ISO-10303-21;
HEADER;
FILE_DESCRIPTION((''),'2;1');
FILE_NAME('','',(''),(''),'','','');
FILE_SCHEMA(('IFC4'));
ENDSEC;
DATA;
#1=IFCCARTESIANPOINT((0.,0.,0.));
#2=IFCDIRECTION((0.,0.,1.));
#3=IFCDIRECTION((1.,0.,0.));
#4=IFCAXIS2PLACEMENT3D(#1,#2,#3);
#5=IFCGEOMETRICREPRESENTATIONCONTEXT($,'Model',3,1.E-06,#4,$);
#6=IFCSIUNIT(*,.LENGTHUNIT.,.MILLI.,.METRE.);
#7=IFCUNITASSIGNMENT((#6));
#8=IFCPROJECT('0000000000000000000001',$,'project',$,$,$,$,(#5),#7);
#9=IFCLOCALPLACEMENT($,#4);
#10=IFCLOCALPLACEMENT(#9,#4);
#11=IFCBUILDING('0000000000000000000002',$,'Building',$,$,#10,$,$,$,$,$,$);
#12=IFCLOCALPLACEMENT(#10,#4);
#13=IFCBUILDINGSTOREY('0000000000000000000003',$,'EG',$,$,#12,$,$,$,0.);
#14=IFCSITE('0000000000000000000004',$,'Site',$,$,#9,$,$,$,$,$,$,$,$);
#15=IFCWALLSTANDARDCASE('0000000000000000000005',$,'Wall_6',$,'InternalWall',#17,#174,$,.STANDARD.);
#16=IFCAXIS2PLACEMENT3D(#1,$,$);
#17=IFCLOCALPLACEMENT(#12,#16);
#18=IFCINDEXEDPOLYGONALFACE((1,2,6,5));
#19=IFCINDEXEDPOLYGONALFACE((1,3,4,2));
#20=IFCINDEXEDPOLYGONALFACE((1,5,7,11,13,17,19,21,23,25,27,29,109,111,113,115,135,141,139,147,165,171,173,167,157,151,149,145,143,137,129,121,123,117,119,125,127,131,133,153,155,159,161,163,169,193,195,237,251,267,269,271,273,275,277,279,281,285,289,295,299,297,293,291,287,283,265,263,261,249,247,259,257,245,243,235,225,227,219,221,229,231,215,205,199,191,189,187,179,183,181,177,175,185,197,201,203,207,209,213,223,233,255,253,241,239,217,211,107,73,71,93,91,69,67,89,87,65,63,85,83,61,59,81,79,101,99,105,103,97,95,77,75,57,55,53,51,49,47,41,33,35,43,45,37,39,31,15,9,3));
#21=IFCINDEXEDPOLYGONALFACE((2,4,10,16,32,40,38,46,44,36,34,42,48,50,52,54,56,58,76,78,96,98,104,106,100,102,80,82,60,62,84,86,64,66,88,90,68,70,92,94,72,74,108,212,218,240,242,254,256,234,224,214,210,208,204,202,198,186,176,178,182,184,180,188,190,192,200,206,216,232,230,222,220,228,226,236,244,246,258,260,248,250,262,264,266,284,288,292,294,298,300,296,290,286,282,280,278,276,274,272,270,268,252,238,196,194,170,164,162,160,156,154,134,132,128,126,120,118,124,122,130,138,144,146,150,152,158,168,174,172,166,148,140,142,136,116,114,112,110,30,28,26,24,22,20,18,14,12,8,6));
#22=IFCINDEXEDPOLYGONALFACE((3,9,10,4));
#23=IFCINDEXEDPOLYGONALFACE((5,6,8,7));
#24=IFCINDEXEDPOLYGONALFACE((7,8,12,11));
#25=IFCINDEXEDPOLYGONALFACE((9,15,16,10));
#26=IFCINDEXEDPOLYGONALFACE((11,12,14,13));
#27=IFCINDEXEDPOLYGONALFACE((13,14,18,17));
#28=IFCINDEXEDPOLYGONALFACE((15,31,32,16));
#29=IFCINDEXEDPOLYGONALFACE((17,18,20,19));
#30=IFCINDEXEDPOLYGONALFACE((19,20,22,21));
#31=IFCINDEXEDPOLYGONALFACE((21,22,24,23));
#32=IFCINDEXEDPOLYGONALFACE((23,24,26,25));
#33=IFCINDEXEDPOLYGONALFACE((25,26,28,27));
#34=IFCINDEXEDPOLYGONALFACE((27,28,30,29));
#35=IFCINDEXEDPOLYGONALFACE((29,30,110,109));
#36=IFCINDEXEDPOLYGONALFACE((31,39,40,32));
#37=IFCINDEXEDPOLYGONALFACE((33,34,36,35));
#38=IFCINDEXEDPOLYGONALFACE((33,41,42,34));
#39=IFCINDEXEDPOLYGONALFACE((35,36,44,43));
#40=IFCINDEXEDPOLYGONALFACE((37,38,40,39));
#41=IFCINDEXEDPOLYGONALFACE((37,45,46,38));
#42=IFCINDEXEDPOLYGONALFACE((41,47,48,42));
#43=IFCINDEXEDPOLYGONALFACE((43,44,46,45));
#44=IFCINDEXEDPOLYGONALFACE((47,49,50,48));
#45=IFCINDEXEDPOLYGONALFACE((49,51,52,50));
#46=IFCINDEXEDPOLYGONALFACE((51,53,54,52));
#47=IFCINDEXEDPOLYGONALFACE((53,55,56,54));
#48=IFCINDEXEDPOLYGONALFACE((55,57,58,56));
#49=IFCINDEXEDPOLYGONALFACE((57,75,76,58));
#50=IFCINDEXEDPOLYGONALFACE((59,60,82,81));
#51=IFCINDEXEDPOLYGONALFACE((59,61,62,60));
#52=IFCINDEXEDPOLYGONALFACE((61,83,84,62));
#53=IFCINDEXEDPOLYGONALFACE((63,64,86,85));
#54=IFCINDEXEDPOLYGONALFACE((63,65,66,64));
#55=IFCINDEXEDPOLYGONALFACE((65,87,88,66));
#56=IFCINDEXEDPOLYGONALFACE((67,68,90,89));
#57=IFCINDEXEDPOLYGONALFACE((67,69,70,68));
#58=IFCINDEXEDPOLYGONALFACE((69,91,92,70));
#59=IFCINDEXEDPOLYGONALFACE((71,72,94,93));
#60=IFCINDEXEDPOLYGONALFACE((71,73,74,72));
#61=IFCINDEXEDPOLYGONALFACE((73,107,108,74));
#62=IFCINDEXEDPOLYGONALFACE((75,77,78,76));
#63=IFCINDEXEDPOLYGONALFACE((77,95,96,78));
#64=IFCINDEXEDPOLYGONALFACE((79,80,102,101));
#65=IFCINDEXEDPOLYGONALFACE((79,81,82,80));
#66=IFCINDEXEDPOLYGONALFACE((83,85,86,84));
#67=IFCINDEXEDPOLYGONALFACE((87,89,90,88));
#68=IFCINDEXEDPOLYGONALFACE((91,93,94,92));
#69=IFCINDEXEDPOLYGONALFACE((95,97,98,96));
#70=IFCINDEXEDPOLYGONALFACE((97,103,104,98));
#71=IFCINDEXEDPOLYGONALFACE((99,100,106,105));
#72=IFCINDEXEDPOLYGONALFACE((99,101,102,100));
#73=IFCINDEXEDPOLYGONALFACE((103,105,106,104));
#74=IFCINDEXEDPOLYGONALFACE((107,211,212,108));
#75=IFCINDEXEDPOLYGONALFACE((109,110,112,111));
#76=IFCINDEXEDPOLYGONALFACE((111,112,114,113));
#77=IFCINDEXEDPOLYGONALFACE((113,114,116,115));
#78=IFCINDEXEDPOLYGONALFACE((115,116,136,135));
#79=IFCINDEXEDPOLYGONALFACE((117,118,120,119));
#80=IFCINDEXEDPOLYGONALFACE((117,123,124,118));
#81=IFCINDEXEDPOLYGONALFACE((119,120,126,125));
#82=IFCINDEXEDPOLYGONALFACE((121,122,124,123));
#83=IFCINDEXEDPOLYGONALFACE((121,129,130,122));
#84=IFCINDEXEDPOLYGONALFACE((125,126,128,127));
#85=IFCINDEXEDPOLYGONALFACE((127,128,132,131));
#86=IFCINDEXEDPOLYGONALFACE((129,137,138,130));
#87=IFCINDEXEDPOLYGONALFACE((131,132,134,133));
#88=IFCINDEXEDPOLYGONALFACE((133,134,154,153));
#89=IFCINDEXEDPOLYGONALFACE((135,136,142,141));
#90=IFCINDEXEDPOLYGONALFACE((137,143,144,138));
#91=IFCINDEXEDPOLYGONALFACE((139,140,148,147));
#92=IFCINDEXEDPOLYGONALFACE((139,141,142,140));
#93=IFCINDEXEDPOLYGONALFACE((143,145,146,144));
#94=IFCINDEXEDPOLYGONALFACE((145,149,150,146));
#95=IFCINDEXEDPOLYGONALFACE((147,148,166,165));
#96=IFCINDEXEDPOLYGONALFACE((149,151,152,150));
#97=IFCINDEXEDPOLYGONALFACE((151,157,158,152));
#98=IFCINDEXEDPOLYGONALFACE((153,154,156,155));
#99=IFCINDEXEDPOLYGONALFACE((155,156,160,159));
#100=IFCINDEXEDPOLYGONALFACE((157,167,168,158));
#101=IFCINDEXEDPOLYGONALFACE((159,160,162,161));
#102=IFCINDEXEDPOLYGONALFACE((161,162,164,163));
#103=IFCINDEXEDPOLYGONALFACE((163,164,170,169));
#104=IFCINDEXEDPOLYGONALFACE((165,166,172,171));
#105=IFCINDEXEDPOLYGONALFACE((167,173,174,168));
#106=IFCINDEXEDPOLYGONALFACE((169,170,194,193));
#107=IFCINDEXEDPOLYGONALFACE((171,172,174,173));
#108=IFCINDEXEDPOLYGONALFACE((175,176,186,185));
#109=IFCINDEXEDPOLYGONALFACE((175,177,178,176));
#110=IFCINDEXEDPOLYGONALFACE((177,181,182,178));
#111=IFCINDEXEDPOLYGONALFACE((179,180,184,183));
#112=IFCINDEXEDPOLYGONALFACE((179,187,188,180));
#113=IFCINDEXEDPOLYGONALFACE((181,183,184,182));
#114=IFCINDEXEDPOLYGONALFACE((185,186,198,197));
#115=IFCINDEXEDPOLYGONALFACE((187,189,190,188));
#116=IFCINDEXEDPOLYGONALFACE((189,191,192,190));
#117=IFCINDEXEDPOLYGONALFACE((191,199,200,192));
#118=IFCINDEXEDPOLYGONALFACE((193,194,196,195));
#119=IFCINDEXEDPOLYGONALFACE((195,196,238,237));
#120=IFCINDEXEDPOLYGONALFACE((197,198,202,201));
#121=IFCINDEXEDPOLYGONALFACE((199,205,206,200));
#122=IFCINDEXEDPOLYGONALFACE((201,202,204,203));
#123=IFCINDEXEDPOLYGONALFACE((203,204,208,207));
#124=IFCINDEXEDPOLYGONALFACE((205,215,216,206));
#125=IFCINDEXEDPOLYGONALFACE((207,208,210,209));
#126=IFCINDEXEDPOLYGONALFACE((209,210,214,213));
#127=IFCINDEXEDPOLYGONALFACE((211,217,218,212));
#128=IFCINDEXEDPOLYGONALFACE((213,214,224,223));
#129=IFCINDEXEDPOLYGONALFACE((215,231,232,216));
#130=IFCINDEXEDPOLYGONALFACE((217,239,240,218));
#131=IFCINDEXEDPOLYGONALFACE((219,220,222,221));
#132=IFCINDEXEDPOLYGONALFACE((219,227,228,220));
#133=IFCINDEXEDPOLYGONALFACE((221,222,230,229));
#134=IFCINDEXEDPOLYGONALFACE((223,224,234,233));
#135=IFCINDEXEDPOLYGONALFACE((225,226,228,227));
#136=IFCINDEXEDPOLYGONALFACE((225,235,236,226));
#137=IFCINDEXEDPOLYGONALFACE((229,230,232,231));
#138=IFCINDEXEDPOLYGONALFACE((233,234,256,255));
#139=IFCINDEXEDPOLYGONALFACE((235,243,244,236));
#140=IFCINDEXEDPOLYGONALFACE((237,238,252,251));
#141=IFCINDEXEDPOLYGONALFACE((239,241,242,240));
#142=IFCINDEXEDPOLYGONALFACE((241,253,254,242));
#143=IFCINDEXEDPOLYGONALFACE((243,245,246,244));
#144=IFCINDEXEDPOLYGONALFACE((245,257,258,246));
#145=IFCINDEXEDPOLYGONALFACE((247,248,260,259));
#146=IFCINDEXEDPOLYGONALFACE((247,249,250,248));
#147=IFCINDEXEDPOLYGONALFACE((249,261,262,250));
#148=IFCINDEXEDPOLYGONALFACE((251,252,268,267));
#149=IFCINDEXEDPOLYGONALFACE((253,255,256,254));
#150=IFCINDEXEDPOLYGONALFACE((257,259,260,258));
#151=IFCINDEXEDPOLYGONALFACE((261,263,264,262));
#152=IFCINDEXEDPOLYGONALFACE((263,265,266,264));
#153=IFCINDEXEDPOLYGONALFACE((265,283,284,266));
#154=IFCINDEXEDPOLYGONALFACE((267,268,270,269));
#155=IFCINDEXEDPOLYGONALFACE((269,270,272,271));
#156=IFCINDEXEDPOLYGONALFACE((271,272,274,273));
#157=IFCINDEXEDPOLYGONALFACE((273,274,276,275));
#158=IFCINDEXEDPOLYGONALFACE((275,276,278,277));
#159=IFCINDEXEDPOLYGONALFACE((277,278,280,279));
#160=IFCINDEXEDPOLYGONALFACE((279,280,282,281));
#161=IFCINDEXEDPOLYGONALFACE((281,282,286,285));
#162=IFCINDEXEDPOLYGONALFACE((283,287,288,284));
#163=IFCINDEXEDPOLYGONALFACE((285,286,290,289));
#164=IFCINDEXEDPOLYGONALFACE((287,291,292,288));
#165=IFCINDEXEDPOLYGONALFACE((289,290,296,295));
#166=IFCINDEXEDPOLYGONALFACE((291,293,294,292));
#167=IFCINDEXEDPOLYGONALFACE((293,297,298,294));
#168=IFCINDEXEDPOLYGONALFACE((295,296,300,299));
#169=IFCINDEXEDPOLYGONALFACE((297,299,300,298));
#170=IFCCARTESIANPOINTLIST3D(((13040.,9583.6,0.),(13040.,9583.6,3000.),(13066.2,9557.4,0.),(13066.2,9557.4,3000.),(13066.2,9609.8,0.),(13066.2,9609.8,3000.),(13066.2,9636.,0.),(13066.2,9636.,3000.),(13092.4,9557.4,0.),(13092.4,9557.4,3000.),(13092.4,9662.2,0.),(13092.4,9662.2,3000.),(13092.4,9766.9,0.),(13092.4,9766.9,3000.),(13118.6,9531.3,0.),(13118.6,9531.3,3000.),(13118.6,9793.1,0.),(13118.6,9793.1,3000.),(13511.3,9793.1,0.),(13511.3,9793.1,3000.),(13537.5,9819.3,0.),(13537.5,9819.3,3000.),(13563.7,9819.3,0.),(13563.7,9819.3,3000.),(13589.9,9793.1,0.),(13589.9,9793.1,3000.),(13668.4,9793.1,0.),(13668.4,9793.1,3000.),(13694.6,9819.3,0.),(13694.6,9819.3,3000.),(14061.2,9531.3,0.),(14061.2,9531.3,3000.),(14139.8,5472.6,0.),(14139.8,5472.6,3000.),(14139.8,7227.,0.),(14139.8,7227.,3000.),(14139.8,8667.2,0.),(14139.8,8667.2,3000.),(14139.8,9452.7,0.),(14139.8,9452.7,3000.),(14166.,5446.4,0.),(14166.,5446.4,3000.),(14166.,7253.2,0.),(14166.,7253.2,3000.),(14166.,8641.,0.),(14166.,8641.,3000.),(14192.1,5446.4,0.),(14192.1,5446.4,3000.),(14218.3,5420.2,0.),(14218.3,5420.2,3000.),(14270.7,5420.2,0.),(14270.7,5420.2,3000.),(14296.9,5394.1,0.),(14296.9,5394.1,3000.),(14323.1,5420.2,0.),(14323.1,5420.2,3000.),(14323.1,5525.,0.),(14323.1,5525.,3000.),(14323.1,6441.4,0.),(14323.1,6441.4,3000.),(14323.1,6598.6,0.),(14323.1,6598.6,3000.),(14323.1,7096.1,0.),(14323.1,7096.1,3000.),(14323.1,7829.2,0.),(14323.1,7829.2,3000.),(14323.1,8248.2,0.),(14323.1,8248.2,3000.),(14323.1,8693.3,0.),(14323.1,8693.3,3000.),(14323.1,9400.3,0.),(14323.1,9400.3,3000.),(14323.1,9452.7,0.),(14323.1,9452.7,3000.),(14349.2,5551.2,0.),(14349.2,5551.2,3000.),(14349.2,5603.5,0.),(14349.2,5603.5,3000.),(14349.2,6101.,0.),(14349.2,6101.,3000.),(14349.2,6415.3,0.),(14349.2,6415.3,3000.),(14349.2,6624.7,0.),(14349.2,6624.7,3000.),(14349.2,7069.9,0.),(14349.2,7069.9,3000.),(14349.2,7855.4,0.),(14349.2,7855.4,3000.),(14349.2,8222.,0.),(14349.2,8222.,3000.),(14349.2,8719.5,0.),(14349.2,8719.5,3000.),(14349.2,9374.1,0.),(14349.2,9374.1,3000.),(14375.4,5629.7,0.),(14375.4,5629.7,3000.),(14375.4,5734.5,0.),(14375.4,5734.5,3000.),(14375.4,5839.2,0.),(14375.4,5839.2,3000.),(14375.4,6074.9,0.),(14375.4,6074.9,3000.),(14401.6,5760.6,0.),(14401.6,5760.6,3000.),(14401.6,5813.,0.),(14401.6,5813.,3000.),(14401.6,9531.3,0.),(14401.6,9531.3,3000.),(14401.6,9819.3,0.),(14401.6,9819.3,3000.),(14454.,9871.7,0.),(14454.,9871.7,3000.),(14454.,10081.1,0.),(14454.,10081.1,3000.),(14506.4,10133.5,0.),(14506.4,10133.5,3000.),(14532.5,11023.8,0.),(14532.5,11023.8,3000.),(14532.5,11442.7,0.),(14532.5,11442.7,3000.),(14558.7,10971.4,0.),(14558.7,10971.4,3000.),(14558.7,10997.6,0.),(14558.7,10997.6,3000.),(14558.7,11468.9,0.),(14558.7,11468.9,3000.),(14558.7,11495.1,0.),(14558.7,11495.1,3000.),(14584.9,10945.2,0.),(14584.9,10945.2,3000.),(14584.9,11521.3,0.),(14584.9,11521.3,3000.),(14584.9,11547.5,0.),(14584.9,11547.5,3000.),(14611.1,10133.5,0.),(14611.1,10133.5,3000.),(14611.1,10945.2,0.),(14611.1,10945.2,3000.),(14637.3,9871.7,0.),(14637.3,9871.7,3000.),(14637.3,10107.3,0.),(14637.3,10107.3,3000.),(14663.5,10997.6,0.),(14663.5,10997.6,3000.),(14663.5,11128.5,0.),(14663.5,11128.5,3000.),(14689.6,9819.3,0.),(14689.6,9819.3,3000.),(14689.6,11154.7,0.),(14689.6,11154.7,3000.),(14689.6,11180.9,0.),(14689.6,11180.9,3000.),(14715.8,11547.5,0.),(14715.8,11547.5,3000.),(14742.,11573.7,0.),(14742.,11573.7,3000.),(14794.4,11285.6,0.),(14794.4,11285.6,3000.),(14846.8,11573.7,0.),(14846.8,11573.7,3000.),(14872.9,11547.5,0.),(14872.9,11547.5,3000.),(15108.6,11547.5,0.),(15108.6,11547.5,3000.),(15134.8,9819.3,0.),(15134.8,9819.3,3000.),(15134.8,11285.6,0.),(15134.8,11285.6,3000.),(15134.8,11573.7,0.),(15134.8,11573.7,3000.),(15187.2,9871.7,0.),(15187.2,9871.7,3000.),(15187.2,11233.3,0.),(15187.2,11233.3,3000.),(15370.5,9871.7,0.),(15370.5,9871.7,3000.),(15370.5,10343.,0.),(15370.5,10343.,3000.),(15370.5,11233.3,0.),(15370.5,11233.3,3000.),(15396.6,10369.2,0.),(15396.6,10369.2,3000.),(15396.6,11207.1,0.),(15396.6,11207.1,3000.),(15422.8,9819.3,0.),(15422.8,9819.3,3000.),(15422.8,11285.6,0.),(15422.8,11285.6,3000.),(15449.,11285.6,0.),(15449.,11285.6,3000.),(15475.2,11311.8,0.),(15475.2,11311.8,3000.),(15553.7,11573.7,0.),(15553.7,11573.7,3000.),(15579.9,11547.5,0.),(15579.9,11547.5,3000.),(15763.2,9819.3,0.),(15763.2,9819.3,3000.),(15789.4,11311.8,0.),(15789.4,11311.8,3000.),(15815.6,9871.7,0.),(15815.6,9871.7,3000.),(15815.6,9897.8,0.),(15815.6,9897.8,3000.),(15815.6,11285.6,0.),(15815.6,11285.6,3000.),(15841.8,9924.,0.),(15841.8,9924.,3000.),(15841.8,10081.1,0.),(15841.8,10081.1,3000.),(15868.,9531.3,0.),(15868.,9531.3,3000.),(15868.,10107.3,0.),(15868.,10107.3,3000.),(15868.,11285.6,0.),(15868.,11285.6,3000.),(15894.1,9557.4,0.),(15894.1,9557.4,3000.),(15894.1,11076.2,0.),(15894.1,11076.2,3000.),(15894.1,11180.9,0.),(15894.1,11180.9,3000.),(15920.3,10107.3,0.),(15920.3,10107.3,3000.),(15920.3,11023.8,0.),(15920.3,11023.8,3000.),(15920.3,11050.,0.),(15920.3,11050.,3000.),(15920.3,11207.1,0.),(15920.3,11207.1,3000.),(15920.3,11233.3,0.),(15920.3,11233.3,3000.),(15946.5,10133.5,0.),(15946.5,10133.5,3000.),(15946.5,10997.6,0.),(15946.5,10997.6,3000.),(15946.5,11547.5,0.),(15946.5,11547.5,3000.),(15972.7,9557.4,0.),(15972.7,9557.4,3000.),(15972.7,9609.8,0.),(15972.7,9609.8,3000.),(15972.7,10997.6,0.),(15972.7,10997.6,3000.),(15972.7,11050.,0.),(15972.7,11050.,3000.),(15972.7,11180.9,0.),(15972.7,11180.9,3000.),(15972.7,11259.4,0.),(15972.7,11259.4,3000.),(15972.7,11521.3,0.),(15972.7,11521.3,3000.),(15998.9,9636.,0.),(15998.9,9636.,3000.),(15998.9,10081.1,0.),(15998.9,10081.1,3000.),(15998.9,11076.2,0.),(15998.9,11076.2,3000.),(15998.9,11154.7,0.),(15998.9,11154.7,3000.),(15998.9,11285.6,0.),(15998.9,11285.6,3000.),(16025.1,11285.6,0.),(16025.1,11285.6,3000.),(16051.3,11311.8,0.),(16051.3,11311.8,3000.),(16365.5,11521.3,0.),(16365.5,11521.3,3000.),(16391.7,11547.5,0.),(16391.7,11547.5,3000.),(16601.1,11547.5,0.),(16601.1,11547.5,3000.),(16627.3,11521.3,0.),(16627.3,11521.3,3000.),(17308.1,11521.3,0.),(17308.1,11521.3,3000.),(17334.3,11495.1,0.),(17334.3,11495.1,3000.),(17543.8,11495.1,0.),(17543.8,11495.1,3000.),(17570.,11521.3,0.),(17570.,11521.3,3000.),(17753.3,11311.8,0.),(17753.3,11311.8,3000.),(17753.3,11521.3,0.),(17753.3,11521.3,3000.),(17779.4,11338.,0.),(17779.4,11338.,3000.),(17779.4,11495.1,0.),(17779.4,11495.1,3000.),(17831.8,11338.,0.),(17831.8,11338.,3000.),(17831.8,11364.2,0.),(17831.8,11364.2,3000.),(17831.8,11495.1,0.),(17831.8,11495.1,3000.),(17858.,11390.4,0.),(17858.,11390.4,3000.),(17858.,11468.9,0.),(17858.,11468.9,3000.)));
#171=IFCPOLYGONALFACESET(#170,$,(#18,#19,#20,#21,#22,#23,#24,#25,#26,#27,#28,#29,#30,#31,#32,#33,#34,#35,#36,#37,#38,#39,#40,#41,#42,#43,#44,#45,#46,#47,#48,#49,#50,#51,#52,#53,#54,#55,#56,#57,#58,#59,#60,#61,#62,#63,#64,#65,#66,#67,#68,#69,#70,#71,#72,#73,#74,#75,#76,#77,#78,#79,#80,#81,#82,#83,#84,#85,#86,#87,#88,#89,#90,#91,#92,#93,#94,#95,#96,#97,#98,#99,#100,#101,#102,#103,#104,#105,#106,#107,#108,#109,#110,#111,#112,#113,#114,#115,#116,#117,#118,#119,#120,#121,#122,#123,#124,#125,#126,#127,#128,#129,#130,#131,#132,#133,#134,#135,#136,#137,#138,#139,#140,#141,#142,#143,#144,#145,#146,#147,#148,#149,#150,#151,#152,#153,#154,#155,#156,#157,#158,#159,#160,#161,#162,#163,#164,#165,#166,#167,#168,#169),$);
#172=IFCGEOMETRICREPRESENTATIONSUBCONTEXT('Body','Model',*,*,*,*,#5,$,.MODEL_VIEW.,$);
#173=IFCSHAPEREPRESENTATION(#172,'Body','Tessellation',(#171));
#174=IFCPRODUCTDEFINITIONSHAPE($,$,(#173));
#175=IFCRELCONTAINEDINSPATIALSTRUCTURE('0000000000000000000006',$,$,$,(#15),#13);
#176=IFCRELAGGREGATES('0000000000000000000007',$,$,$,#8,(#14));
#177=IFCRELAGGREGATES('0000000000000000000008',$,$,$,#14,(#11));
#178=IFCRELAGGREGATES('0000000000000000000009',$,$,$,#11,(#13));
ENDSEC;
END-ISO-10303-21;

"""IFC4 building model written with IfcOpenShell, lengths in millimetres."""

from ifc_helpers import new_model, si_unit, origin_with_axes, place, context, subcontext, project, spatial, polyline, outline, extrude, element, save


model = new_model("IFC4")

# Units and contexts
model_context = context("Model", 3, precision=1e-06, world=origin_with_axes())
body_context = subcontext(model_context, "Body", "Model", "MODEL_VIEW")
ifc_project = project(units=[si_unit("LENGTHUNIT", "METRE", prefix="MILLI")], contexts=[model_context])

# Site, building, storey
site_placement = place(None, origin_with_axes())
site = spatial("IfcSite", under=ifc_project, at=site_placement, Name="Site")
building_placement = place(site_placement, origin_with_axes())
building = spatial("IfcBuilding", under=site, at=building_placement, Name="Building")
storey_placement = place(building_placement, origin_with_axes())
storey = spatial("IfcBuildingStorey", under=building, at=storey_placement, Name="EG", Elevation=0.0)

# Wall
wall_1_placement = place(storey_placement, origin_with_axes())
element("IfcWallStandardCase", 1, at=wall_1_placement, inside=storey, Name="Wall_6", ObjectType="InternalWall", PredefinedType="STANDARD", context=body_context, shape_type="SweptSolid", body=[
    extrude(outline(polyline([(14296.9, 5394.1, 0.0), (14270.7, 5420.2, 0.0), (14218.3, 5420.2, 0.0), (14192.1, 5446.4, 0.0), (14166.0, 5446.4, 0.0), (14139.8, 5472.6, 0.0), (14139.8, 7227.0, 0.0), (14166.0, 7253.2, 0.0), (14166.0, 8641.0, 0.0), (14139.8, 8667.2, 0.0), (14139.8, 9452.7, 0.0), (14061.2, 9531.3, 0.0), (13118.6, 9531.3, 0.0), (13092.4, 9557.4, 0.0), (13066.2, 9557.4, 0.0), (13040.0, 9583.6, 0.0), (13066.2, 9609.8, 0.0), (13066.2, 9636.0, 0.0), (13092.4, 9662.2, 0.0), (13092.4, 9766.9, 0.0), (13118.6, 9793.1, 0.0), (13511.3, 9793.1, 0.0), (13537.5, 9819.3, 0.0), (13563.7, 9819.3, 0.0), (13589.9, 9793.1, 0.0), (13668.4, 9793.1, 0.0), (13694.6, 9819.3, 0.0), (14401.6, 9819.3, 0.0), (14454.0, 9871.7, 0.0), (14454.0, 10081.1, 0.0), (14506.4, 10133.5, 0.0), (14611.1, 10133.5, 0.0), (14637.3, 10107.3, 0.0), (14637.3, 9871.7, 0.0), (14689.6, 9819.3, 0.0), (15134.8, 9819.3, 0.0), (15187.2, 9871.7, 0.0), (15187.2, 11233.3, 0.0), (15134.8, 11285.6, 0.0), (14794.4, 11285.6, 0.0), (14689.6, 11180.9, 0.0), (14689.6, 11154.7, 0.0), (14663.5, 11128.5, 0.0), (14663.5, 10997.6, 0.0), (14611.1, 10945.2, 0.0), (14584.9, 10945.2, 0.0), (14558.7, 10971.4, 0.0), (14558.7, 10997.6, 0.0), (14532.5, 11023.8, 0.0), (14532.5, 11442.7, 0.0), (14558.7, 11468.9, 0.0), (14558.7, 11495.1, 0.0), (14584.9, 11521.3, 0.0), (14584.9, 11547.5, 0.0), (14715.8, 11547.5, 0.0), (14742.0, 11573.7, 0.0), (14846.8, 11573.7, 0.0), (14872.9, 11547.5, 0.0), (15108.6, 11547.5, 0.0), (15134.8, 11573.7, 0.0), (15553.7, 11573.7, 0.0), (15579.9, 11547.5, 0.0), (15946.5, 11547.5, 0.0), (15972.7, 11521.3, 0.0), (16365.5, 11521.3, 0.0), (16391.7, 11547.5, 0.0), (16601.1, 11547.5, 0.0), (16627.3, 11521.3, 0.0), (17308.1, 11521.3, 0.0), (17334.3, 11495.1, 0.0), (17543.8, 11495.1, 0.0), (17570.0, 11521.3, 0.0), (17753.3, 11521.3, 0.0), (17779.4, 11495.1, 0.0), (17831.8, 11495.1, 0.0), (17858.0, 11468.9, 0.0), (17858.0, 11390.4, 0.0), (17831.8, 11364.2, 0.0), (17831.8, 11338.0, 0.0), (17779.4, 11338.0, 0.0), (17753.3, 11311.8, 0.0), (16051.3, 11311.8, 0.0), (16025.1, 11285.6, 0.0), (15998.9, 11285.6, 0.0), (15972.7, 11259.4, 0.0), (15972.7, 11180.9, 0.0), (15998.9, 11154.7, 0.0), (15998.9, 11076.2, 0.0), (15972.7, 11050.0, 0.0), (15972.7, 10997.6, 0.0), (15946.5, 10997.6, 0.0), (15920.3, 11023.8, 0.0), (15920.3, 11050.0, 0.0), (15894.1, 11076.2, 0.0), (15894.1, 11180.9, 0.0), (15920.3, 11207.1, 0.0), (15920.3, 11233.3, 0.0), (15868.0, 11285.6, 0.0), (15815.6, 11285.6, 0.0), (15789.4, 11311.8, 0.0), (15475.2, 11311.8, 0.0), (15449.0, 11285.6, 0.0), (15422.8, 11285.6, 0.0), (15370.5, 11233.3, 0.0), (15396.6, 11207.1, 0.0), (15396.6, 10369.2, 0.0), (15370.5, 10343.0, 0.0), (15370.5, 9871.7, 0.0), (15422.8, 9819.3, 0.0), (15763.2, 9819.3, 0.0), (15815.6, 9871.7, 0.0), (15815.6, 9897.8, 0.0), (15841.8, 9924.0, 0.0), (15841.8, 10081.1, 0.0), (15868.0, 10107.3, 0.0), (15920.3, 10107.3, 0.0), (15946.5, 10133.5, 0.0), (15998.9, 10081.1, 0.0), (15998.9, 9636.0, 0.0), (15972.7, 9609.8, 0.0), (15972.7, 9557.4, 0.0), (15894.1, 9557.4, 0.0), (15868.0, 9531.3, 0.0), (14401.6, 9531.3, 0.0), (14323.1, 9452.7, 0.0), (14323.1, 9400.3, 0.0), (14349.2, 9374.1, 0.0), (14349.2, 8719.5, 0.0), (14323.1, 8693.3, 0.0), (14323.1, 8248.2, 0.0), (14349.2, 8222.0, 0.0), (14349.2, 7855.4, 0.0), (14323.1, 7829.2, 0.0), (14323.1, 7096.1, 0.0), (14349.2, 7069.9, 0.0), (14349.2, 6624.7, 0.0), (14323.1, 6598.6, 0.0), (14323.1, 6441.4, 0.0), (14349.2, 6415.3, 0.0), (14349.2, 6101.0, 0.0), (14375.4, 6074.9, 0.0), (14375.4, 5839.2, 0.0), (14401.6, 5813.0, 0.0), (14401.6, 5760.6, 0.0), (14375.4, 5734.5, 0.0), (14375.4, 5629.7, 0.0), (14349.2, 5603.5, 0.0), (14349.2, 5551.2, 0.0), (14323.1, 5525.0, 0.0), (14323.1, 5420.2, 0.0), (14296.9, 5394.1, 0.0)])), origin_with_axes(), (0.0, 0.0, 1.0), 3000.0),
])

save(model, "model.ifc")
